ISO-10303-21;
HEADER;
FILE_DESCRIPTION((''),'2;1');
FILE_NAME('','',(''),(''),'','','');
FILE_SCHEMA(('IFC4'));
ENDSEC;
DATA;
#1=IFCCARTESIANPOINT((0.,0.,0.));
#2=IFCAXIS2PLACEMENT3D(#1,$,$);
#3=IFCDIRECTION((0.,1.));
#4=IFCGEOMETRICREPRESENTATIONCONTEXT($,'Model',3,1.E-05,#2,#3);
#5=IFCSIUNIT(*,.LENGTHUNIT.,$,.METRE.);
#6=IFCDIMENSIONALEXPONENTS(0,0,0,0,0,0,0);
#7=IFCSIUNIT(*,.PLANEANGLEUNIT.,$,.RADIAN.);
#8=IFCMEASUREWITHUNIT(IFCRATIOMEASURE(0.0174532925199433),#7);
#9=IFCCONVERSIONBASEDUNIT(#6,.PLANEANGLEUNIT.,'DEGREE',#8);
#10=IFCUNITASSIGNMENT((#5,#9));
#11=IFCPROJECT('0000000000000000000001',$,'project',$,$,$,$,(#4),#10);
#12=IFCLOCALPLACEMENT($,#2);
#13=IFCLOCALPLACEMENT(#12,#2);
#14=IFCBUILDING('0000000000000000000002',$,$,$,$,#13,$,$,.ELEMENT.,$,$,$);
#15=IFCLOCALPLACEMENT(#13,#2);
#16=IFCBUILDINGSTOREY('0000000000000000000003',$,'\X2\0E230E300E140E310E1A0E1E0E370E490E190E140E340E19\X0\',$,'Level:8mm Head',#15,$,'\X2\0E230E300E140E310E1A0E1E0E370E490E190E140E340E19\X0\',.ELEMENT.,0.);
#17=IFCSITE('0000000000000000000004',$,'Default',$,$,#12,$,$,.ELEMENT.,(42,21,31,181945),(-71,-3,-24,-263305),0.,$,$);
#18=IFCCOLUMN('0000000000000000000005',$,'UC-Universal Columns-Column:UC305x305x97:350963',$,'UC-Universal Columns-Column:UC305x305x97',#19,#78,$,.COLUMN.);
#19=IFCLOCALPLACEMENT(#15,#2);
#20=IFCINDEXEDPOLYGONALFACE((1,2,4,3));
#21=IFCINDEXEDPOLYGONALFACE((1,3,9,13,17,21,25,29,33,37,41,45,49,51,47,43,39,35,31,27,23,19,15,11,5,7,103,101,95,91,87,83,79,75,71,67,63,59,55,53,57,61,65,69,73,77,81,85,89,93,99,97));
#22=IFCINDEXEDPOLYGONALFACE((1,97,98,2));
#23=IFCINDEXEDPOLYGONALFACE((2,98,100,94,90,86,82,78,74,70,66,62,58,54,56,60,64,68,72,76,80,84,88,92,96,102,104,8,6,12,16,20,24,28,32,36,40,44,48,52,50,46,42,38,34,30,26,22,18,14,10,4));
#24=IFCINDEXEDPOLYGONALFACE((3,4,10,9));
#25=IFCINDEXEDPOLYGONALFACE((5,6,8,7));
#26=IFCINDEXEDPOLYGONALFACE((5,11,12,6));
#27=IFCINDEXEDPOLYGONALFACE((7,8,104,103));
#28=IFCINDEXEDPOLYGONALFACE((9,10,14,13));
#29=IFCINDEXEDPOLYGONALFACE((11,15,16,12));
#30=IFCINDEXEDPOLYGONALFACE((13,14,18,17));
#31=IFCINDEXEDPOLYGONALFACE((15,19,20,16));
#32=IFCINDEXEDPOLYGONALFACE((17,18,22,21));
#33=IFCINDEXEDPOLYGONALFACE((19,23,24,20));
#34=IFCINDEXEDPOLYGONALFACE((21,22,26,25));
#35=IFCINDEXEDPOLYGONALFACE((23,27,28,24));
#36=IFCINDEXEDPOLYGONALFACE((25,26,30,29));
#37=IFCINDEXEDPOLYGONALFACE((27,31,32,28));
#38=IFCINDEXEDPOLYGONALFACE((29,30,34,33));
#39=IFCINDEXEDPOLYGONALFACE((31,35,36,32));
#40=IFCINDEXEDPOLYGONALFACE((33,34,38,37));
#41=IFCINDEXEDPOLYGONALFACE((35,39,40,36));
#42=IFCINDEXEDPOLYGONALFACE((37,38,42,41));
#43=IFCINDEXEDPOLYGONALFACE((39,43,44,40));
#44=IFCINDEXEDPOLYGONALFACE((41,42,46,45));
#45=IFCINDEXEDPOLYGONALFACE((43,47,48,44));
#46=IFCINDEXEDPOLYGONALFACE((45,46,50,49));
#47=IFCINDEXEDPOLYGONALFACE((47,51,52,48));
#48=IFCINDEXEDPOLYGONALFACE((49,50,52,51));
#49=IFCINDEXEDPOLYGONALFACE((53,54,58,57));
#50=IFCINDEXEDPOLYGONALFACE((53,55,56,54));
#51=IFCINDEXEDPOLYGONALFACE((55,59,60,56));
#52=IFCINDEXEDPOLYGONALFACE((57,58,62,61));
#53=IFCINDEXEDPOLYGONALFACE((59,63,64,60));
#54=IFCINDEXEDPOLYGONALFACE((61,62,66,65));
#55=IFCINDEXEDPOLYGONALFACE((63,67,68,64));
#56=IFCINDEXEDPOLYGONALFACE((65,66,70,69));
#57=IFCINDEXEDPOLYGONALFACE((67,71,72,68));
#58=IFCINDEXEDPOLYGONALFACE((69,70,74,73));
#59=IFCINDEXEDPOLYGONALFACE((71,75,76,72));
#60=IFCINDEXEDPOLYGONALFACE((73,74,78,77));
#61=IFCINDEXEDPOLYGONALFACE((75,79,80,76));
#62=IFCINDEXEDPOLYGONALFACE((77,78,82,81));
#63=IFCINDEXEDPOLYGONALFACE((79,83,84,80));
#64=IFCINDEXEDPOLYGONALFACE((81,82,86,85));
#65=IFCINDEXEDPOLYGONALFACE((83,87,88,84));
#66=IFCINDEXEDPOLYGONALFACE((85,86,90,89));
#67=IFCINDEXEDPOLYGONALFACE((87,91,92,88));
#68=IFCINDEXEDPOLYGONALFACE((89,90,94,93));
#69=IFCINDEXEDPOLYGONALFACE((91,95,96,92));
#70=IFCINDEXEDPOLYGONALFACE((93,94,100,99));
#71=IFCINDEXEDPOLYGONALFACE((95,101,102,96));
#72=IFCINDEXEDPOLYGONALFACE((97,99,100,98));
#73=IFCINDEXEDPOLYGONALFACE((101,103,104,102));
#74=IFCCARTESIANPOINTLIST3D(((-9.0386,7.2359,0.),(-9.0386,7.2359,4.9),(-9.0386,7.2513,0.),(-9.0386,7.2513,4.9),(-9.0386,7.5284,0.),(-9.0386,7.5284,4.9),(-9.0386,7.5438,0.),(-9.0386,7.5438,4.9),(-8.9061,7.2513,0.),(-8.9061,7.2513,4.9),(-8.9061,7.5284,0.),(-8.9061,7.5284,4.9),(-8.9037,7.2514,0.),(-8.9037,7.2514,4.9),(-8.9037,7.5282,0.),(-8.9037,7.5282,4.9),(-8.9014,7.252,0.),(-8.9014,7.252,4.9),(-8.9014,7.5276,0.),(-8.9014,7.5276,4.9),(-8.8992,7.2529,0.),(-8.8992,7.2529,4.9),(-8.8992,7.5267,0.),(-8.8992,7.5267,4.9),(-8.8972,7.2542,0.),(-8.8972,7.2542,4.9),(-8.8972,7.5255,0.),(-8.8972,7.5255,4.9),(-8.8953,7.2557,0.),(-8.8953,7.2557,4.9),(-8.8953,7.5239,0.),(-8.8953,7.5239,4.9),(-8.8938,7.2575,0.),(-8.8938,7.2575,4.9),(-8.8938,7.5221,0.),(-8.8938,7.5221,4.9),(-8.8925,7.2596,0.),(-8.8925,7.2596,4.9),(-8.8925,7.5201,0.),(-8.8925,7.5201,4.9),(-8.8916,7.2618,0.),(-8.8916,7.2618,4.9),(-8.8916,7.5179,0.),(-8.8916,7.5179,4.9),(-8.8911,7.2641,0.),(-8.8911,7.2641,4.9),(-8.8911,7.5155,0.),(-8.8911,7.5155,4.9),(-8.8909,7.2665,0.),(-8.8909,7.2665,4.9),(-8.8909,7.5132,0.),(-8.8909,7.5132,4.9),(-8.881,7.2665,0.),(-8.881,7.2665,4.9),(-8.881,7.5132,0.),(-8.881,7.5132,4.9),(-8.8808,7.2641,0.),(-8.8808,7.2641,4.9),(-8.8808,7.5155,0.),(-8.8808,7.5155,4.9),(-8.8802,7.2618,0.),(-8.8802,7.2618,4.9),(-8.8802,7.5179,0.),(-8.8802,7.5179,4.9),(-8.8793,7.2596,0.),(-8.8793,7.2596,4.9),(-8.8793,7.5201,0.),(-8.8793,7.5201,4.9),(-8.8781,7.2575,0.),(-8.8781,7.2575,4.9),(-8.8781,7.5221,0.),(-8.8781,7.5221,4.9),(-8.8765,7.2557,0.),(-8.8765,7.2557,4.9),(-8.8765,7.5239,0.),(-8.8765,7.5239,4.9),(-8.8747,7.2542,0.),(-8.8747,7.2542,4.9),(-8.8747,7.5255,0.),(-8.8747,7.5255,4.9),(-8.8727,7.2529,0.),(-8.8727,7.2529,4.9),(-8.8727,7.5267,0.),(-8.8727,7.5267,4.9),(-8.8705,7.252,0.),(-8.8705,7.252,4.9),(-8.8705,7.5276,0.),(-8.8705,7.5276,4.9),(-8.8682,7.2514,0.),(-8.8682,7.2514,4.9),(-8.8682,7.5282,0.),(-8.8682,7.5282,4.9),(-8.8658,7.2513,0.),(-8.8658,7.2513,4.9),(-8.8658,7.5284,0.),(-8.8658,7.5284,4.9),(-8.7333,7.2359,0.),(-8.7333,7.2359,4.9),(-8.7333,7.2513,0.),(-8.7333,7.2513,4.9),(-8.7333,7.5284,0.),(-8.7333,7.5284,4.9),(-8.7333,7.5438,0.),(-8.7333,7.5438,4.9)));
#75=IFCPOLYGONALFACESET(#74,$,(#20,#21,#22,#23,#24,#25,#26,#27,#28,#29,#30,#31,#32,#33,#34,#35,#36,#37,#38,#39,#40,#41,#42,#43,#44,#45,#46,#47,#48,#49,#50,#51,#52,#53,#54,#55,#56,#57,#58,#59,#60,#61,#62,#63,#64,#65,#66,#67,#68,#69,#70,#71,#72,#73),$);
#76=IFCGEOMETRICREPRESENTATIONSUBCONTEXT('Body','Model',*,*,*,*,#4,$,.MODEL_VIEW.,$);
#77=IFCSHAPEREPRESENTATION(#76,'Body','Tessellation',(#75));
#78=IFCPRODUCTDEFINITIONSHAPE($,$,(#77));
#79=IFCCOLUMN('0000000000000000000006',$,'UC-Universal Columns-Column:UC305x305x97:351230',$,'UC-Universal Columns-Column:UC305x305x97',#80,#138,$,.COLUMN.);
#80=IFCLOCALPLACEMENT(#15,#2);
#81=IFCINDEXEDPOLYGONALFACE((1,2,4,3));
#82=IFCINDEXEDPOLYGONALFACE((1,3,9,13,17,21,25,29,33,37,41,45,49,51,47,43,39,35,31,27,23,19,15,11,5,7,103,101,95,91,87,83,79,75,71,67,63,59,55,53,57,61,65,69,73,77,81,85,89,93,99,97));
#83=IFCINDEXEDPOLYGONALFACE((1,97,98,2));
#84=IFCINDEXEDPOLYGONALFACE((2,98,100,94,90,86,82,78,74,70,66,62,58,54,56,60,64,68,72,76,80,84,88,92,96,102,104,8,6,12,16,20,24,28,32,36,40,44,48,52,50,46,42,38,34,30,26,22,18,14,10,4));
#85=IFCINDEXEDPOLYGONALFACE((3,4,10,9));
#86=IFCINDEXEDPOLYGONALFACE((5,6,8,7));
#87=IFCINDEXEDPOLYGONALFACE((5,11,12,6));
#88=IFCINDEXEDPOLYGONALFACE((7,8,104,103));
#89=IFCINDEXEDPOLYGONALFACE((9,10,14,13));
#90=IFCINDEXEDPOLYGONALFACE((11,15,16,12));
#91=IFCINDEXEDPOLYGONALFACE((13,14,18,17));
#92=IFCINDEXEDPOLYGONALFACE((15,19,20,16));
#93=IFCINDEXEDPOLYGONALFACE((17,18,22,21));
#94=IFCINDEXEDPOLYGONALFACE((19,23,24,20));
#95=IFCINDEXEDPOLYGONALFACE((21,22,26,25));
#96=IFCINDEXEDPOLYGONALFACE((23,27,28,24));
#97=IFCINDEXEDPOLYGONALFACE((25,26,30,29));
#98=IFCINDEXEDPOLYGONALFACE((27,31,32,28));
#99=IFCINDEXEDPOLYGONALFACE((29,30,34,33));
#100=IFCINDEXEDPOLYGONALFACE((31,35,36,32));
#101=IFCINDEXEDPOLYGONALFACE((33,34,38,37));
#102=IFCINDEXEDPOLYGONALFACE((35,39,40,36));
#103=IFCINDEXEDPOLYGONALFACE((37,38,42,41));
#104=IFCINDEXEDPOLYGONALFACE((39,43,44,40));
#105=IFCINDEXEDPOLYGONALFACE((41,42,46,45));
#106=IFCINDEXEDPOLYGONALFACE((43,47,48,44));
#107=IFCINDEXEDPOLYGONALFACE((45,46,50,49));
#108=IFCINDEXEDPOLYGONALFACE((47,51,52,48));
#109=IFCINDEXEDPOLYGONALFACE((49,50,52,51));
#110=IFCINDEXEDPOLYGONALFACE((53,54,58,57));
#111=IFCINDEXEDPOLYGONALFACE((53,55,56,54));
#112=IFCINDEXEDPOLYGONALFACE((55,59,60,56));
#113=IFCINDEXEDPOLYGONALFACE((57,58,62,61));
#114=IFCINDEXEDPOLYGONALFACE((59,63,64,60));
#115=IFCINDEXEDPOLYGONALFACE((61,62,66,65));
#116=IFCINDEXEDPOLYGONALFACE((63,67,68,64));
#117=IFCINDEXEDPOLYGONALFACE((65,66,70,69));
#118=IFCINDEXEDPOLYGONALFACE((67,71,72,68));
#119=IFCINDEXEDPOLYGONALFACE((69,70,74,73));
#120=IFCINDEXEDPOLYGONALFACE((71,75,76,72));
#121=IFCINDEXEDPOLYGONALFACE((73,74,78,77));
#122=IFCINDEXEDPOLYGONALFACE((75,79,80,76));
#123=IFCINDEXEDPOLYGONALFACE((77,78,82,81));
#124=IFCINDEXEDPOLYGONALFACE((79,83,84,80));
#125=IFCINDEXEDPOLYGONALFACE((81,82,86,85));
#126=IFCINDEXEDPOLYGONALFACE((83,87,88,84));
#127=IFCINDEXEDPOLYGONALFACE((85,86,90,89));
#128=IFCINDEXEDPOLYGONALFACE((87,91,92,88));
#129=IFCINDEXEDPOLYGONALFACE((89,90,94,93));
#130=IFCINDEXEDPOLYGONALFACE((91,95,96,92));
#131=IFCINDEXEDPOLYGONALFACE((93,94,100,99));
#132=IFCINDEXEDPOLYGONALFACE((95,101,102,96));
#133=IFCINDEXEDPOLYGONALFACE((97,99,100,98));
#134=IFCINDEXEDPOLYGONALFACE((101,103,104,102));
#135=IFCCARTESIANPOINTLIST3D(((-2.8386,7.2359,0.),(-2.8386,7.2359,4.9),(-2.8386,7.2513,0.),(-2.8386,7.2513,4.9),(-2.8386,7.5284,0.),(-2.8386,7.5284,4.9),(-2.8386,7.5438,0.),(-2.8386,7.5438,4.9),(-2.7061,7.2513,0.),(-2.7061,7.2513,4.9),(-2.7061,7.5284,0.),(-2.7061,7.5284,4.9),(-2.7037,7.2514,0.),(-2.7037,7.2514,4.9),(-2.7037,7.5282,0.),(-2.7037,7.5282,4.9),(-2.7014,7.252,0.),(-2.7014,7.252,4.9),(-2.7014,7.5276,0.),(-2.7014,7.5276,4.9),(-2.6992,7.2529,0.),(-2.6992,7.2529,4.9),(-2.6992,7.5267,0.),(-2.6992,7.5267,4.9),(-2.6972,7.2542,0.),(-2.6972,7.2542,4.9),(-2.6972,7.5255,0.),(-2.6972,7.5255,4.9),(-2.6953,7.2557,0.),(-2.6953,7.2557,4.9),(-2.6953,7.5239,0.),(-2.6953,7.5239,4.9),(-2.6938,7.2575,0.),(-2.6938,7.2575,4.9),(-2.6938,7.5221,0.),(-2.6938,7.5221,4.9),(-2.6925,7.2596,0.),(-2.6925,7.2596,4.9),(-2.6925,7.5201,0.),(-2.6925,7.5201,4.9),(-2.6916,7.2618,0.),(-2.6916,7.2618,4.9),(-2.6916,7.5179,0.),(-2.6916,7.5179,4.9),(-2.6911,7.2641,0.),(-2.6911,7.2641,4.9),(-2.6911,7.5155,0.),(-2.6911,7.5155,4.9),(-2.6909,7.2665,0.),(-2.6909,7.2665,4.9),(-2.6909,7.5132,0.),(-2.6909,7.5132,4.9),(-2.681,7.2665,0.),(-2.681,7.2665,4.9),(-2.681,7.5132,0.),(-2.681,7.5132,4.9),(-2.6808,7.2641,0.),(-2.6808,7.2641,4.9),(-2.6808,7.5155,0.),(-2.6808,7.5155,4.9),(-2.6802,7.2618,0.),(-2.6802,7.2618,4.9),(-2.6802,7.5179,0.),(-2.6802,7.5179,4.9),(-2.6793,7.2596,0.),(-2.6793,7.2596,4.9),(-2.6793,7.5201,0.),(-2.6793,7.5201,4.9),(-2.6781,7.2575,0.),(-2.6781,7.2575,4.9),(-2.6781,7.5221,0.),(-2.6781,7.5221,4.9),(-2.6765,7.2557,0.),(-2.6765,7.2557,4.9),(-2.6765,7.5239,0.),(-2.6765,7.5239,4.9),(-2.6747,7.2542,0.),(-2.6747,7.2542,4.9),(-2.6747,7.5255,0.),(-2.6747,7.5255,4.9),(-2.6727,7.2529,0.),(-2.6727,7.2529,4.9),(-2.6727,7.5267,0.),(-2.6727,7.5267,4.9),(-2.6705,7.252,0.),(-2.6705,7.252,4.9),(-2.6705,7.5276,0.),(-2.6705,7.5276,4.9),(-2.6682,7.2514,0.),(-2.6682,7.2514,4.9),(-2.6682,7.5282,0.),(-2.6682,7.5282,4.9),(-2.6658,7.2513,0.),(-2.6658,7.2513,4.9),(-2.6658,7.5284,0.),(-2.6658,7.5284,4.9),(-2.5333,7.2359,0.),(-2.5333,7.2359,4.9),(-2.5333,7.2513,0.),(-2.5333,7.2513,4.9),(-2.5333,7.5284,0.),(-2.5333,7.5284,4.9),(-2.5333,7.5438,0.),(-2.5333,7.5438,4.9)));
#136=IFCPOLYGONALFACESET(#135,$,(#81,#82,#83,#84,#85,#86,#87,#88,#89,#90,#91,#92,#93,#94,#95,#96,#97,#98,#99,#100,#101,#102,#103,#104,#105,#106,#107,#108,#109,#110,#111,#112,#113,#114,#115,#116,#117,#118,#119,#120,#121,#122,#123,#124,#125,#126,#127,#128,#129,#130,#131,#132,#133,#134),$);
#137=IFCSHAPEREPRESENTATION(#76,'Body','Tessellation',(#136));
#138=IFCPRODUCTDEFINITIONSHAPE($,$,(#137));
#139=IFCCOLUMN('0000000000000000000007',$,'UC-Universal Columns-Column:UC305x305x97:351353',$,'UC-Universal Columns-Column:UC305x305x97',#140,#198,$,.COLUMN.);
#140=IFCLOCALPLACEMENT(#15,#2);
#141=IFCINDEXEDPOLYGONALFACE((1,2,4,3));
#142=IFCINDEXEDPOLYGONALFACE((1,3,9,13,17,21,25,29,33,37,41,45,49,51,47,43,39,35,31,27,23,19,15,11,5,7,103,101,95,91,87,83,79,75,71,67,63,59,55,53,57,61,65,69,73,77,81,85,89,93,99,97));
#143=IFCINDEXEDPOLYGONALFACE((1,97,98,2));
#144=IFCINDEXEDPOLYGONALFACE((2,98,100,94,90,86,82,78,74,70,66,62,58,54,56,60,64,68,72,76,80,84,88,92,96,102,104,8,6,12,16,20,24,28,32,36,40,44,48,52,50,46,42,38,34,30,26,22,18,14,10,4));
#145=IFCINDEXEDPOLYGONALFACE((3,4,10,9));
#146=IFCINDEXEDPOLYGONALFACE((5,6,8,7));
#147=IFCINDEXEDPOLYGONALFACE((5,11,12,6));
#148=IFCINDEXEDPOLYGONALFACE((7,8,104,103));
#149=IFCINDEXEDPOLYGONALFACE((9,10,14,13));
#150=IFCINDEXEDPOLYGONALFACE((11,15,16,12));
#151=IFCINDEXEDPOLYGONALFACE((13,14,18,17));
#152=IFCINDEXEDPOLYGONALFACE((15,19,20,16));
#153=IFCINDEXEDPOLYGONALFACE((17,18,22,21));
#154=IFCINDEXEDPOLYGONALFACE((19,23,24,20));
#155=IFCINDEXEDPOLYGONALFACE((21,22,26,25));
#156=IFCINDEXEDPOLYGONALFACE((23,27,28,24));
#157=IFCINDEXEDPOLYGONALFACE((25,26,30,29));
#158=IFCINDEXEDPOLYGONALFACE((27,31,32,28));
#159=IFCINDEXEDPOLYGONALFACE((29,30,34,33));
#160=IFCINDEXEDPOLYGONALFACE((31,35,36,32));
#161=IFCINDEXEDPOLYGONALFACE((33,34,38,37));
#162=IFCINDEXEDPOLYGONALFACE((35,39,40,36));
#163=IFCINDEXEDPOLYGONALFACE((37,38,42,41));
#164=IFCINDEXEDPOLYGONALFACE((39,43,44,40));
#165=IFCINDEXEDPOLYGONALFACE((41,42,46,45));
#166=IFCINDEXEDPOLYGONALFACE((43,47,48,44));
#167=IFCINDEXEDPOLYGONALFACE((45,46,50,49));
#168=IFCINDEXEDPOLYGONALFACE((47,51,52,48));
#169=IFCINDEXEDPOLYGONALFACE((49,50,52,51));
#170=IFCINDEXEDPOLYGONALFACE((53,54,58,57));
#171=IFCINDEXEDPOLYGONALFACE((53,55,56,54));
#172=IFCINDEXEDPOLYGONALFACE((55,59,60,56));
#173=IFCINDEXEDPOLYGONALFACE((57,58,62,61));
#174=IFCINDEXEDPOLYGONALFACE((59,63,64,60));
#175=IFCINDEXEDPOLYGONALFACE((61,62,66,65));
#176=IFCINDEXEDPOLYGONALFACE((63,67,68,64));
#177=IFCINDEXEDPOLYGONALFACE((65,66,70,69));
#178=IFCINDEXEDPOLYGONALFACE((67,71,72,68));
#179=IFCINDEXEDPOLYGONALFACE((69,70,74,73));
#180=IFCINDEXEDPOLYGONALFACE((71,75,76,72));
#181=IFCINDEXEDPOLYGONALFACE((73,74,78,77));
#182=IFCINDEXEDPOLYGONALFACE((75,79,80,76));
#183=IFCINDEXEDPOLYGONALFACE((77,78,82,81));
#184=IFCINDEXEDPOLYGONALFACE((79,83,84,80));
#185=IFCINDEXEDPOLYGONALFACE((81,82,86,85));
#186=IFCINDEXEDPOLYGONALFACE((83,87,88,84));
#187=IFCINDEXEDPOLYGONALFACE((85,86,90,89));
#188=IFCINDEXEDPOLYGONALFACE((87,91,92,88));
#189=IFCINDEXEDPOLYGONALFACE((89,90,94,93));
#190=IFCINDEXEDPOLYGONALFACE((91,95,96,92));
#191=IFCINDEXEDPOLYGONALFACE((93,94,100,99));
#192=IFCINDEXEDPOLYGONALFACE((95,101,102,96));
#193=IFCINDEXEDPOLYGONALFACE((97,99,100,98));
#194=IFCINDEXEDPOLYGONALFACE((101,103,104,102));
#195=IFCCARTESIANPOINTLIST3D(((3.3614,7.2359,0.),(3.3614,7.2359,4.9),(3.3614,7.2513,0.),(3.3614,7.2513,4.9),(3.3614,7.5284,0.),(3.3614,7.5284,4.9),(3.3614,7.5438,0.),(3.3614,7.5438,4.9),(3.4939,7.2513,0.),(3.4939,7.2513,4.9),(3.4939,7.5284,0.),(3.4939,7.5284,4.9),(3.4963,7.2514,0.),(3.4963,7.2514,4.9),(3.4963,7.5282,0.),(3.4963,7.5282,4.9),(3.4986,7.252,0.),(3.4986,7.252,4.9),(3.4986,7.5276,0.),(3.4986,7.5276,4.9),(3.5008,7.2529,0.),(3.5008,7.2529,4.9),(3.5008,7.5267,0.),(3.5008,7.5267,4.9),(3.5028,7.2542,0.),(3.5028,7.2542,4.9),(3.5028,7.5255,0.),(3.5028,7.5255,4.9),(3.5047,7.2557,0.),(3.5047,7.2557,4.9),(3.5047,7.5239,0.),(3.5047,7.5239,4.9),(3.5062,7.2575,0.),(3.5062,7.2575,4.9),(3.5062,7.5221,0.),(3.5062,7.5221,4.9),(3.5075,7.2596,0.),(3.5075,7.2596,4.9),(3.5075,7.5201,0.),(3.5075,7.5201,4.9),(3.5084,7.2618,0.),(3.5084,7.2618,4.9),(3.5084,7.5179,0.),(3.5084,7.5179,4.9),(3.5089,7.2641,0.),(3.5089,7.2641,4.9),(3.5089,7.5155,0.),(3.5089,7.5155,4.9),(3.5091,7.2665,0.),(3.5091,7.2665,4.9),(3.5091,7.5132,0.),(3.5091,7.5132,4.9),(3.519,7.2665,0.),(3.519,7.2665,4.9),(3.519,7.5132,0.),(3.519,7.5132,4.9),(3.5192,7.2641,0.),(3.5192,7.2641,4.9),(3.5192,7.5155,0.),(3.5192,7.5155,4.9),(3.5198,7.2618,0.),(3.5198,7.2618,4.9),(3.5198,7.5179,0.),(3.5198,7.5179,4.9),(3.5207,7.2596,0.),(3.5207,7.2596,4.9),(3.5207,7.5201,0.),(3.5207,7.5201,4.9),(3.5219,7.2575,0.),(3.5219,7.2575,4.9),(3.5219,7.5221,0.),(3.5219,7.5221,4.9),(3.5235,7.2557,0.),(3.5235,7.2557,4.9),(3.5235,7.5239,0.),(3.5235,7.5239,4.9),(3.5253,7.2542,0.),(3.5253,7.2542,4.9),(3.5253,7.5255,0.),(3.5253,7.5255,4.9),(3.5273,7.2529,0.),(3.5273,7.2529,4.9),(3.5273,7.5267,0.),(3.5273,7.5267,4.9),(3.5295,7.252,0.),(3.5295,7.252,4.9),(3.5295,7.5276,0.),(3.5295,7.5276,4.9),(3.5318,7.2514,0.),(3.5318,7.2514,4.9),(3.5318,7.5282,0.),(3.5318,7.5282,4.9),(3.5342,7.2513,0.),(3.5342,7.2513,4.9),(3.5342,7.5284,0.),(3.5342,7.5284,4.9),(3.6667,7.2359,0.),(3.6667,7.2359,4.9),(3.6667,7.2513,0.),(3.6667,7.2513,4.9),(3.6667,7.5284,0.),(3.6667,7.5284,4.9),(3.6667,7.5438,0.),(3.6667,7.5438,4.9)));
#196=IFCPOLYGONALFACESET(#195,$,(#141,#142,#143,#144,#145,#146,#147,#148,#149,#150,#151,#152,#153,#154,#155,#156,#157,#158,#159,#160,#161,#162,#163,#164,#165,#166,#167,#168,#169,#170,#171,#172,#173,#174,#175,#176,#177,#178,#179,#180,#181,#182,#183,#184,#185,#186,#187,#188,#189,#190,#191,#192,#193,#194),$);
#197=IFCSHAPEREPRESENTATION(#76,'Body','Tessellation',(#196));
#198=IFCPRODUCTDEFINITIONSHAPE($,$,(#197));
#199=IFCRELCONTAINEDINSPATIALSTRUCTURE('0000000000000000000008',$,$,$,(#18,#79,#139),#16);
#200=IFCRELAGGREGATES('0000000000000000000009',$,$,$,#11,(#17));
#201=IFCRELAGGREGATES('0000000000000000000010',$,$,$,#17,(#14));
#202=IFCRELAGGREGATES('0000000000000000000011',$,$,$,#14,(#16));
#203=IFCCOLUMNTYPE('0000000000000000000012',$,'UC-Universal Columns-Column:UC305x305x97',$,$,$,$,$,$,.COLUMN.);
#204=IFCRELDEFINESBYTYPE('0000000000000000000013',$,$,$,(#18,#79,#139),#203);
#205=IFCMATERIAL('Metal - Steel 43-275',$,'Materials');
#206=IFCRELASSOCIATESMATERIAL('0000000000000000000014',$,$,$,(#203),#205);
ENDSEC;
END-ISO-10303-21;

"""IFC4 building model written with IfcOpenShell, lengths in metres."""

from ifc_helpers import new_model, entity, si_unit, converted_unit, direction, frame, origin, place, context, subcontext, project, spatial, indexed_curve, outline, extrude, source, transform, mapped, material, type_object, type_shapes, element, save


model = new_model("IFC4")

# Units and contexts
model_context = context("Model", 3, precision=1e-05, world=origin(), true_north=direction((0.0, 1.0)))
body_context = subcontext(model_context, "Body", "Model", "MODEL_VIEW")
ifc_project = project(units=[si_unit("LENGTHUNIT", "METRE"), converted_unit("PLANEANGLEUNIT", "DEGREE", entity("IfcRatioMeasure", 0.0174532925199433), si_unit("PLANEANGLEUNIT", "RADIAN"), dimensions=[0, 0, 0, 0, 0, 0, 0])], contexts=[model_context])

# Site, building, storey
site_placement = place(None, origin())
site = spatial("IfcSite", under=ifc_project, at=site_placement, Name="Default", CompositionType="ELEMENT", RefLatitude=(42, 21, 31, 181945), RefLongitude=(-71, -3, -24, -263305), RefElevation=0.0)
building_placement = place(site_placement, origin())
building = spatial("IfcBuilding", under=site, at=building_placement, CompositionType="ELEMENT")
storey_placement = place(building_placement, origin())
storey = spatial("IfcBuildingStorey", under=building, at=storey_placement, Name="ระดับพื้นดิน", ObjectType="Level:8mm Head", LongName="ระดับพื้นดิน", CompositionType="ELEMENT", Elevation=0.0)

# Columns
ifc_material_1 = material(Name="Metal - Steel 43-275", Category="Materials")
column_type_1 = type_object("IfcColumnType", Name="UC-Universal Columns-Column:UC305x305x97", PredefinedType="COLUMN", material=ifc_material_1)
shared_shape_1 = source(origin(), body_context, "Body", "SweptSolid", [
    extrude(outline(indexed_curve([(-0.154, -0.1527), (-0.1386, -0.1527), (-0.1386, -0.0202), (-0.1384, -0.0178), (-0.1378, -0.0155), (-0.1369, -0.0132), (-0.1356, -0.0112), (-0.1341, -0.0094), (-0.1323, -0.0079), (-0.1303, -0.0066), (-0.128, -0.0057), (-0.1257, -0.0051), (-0.1234, -0.0049), (0.1234, -0.0049), (0.1257, -0.0051), (0.128, -0.0057), (0.1303, -0.0066), (0.1323, -0.0079), (0.1341, -0.0094), (0.1356, -0.0112), (0.1369, -0.0132), (0.1378, -0.0155), (0.1384, -0.0178), (0.1386, -0.0201), (0.1386, -0.1527), (0.154, -0.1527), (0.154, 0.1527), (0.1386, 0.1527), (0.1386, 0.0202), (0.1384, 0.0178), (0.1378, 0.0155), (0.1369, 0.0132), (0.1356, 0.0112), (0.1341, 0.0094), (0.1323, 0.0079), (0.1303, 0.0066), (0.128, 0.0057), (0.1257, 0.0051), (0.1234, 0.005), (-0.1234, 0.005), (-0.1257, 0.0051), (-0.128, 0.0057), (-0.1303, 0.0066), (-0.1323, 0.0079), (-0.1341, 0.0094), (-0.1356, 0.0112), (-0.1369, 0.0132), (-0.1378, 0.0155), (-0.1384, 0.0178), (-0.1386, 0.0202), (-0.1386, 0.1527), (-0.154, 0.1527), (-0.154, -0.1527)], self_intersect=False)), frame((0.0, 0.0, 0.0), z_axis=(0.0, 0.0, 1.0), x_axis=(0.0, -1.0, 0.0)), (0.0, 0.0, 1.0), 4.9),
])
type_shapes(column_type_1, [shared_shape_1])
for number, where, name in (
    (1, (-8.8859, 7.3898, 0.0), "UC-Universal Columns-Column:UC305x305x97:350963"),
    (2, (-2.6859, 7.3898, 0.0), "UC-Universal Columns-Column:UC305x305x97:351230"),
    (3, (3.5141, 7.3898, 0.0), "UC-Universal Columns-Column:UC305x305x97:351353"),
):
    element("IfcColumn", number, at=place(storey_placement, frame(where)), inside=storey, type_object=column_type_1, Name=name, ObjectType="UC-Universal Columns-Column:UC305x305x97", PredefinedType="COLUMN", context=body_context, shape_type="MappedRepresentation", body=[
        mapped(shared_shape_1, transform((0.0, 0.0, 0.0), scale=1.0)),
    ])

save(model, "model.ifc")
